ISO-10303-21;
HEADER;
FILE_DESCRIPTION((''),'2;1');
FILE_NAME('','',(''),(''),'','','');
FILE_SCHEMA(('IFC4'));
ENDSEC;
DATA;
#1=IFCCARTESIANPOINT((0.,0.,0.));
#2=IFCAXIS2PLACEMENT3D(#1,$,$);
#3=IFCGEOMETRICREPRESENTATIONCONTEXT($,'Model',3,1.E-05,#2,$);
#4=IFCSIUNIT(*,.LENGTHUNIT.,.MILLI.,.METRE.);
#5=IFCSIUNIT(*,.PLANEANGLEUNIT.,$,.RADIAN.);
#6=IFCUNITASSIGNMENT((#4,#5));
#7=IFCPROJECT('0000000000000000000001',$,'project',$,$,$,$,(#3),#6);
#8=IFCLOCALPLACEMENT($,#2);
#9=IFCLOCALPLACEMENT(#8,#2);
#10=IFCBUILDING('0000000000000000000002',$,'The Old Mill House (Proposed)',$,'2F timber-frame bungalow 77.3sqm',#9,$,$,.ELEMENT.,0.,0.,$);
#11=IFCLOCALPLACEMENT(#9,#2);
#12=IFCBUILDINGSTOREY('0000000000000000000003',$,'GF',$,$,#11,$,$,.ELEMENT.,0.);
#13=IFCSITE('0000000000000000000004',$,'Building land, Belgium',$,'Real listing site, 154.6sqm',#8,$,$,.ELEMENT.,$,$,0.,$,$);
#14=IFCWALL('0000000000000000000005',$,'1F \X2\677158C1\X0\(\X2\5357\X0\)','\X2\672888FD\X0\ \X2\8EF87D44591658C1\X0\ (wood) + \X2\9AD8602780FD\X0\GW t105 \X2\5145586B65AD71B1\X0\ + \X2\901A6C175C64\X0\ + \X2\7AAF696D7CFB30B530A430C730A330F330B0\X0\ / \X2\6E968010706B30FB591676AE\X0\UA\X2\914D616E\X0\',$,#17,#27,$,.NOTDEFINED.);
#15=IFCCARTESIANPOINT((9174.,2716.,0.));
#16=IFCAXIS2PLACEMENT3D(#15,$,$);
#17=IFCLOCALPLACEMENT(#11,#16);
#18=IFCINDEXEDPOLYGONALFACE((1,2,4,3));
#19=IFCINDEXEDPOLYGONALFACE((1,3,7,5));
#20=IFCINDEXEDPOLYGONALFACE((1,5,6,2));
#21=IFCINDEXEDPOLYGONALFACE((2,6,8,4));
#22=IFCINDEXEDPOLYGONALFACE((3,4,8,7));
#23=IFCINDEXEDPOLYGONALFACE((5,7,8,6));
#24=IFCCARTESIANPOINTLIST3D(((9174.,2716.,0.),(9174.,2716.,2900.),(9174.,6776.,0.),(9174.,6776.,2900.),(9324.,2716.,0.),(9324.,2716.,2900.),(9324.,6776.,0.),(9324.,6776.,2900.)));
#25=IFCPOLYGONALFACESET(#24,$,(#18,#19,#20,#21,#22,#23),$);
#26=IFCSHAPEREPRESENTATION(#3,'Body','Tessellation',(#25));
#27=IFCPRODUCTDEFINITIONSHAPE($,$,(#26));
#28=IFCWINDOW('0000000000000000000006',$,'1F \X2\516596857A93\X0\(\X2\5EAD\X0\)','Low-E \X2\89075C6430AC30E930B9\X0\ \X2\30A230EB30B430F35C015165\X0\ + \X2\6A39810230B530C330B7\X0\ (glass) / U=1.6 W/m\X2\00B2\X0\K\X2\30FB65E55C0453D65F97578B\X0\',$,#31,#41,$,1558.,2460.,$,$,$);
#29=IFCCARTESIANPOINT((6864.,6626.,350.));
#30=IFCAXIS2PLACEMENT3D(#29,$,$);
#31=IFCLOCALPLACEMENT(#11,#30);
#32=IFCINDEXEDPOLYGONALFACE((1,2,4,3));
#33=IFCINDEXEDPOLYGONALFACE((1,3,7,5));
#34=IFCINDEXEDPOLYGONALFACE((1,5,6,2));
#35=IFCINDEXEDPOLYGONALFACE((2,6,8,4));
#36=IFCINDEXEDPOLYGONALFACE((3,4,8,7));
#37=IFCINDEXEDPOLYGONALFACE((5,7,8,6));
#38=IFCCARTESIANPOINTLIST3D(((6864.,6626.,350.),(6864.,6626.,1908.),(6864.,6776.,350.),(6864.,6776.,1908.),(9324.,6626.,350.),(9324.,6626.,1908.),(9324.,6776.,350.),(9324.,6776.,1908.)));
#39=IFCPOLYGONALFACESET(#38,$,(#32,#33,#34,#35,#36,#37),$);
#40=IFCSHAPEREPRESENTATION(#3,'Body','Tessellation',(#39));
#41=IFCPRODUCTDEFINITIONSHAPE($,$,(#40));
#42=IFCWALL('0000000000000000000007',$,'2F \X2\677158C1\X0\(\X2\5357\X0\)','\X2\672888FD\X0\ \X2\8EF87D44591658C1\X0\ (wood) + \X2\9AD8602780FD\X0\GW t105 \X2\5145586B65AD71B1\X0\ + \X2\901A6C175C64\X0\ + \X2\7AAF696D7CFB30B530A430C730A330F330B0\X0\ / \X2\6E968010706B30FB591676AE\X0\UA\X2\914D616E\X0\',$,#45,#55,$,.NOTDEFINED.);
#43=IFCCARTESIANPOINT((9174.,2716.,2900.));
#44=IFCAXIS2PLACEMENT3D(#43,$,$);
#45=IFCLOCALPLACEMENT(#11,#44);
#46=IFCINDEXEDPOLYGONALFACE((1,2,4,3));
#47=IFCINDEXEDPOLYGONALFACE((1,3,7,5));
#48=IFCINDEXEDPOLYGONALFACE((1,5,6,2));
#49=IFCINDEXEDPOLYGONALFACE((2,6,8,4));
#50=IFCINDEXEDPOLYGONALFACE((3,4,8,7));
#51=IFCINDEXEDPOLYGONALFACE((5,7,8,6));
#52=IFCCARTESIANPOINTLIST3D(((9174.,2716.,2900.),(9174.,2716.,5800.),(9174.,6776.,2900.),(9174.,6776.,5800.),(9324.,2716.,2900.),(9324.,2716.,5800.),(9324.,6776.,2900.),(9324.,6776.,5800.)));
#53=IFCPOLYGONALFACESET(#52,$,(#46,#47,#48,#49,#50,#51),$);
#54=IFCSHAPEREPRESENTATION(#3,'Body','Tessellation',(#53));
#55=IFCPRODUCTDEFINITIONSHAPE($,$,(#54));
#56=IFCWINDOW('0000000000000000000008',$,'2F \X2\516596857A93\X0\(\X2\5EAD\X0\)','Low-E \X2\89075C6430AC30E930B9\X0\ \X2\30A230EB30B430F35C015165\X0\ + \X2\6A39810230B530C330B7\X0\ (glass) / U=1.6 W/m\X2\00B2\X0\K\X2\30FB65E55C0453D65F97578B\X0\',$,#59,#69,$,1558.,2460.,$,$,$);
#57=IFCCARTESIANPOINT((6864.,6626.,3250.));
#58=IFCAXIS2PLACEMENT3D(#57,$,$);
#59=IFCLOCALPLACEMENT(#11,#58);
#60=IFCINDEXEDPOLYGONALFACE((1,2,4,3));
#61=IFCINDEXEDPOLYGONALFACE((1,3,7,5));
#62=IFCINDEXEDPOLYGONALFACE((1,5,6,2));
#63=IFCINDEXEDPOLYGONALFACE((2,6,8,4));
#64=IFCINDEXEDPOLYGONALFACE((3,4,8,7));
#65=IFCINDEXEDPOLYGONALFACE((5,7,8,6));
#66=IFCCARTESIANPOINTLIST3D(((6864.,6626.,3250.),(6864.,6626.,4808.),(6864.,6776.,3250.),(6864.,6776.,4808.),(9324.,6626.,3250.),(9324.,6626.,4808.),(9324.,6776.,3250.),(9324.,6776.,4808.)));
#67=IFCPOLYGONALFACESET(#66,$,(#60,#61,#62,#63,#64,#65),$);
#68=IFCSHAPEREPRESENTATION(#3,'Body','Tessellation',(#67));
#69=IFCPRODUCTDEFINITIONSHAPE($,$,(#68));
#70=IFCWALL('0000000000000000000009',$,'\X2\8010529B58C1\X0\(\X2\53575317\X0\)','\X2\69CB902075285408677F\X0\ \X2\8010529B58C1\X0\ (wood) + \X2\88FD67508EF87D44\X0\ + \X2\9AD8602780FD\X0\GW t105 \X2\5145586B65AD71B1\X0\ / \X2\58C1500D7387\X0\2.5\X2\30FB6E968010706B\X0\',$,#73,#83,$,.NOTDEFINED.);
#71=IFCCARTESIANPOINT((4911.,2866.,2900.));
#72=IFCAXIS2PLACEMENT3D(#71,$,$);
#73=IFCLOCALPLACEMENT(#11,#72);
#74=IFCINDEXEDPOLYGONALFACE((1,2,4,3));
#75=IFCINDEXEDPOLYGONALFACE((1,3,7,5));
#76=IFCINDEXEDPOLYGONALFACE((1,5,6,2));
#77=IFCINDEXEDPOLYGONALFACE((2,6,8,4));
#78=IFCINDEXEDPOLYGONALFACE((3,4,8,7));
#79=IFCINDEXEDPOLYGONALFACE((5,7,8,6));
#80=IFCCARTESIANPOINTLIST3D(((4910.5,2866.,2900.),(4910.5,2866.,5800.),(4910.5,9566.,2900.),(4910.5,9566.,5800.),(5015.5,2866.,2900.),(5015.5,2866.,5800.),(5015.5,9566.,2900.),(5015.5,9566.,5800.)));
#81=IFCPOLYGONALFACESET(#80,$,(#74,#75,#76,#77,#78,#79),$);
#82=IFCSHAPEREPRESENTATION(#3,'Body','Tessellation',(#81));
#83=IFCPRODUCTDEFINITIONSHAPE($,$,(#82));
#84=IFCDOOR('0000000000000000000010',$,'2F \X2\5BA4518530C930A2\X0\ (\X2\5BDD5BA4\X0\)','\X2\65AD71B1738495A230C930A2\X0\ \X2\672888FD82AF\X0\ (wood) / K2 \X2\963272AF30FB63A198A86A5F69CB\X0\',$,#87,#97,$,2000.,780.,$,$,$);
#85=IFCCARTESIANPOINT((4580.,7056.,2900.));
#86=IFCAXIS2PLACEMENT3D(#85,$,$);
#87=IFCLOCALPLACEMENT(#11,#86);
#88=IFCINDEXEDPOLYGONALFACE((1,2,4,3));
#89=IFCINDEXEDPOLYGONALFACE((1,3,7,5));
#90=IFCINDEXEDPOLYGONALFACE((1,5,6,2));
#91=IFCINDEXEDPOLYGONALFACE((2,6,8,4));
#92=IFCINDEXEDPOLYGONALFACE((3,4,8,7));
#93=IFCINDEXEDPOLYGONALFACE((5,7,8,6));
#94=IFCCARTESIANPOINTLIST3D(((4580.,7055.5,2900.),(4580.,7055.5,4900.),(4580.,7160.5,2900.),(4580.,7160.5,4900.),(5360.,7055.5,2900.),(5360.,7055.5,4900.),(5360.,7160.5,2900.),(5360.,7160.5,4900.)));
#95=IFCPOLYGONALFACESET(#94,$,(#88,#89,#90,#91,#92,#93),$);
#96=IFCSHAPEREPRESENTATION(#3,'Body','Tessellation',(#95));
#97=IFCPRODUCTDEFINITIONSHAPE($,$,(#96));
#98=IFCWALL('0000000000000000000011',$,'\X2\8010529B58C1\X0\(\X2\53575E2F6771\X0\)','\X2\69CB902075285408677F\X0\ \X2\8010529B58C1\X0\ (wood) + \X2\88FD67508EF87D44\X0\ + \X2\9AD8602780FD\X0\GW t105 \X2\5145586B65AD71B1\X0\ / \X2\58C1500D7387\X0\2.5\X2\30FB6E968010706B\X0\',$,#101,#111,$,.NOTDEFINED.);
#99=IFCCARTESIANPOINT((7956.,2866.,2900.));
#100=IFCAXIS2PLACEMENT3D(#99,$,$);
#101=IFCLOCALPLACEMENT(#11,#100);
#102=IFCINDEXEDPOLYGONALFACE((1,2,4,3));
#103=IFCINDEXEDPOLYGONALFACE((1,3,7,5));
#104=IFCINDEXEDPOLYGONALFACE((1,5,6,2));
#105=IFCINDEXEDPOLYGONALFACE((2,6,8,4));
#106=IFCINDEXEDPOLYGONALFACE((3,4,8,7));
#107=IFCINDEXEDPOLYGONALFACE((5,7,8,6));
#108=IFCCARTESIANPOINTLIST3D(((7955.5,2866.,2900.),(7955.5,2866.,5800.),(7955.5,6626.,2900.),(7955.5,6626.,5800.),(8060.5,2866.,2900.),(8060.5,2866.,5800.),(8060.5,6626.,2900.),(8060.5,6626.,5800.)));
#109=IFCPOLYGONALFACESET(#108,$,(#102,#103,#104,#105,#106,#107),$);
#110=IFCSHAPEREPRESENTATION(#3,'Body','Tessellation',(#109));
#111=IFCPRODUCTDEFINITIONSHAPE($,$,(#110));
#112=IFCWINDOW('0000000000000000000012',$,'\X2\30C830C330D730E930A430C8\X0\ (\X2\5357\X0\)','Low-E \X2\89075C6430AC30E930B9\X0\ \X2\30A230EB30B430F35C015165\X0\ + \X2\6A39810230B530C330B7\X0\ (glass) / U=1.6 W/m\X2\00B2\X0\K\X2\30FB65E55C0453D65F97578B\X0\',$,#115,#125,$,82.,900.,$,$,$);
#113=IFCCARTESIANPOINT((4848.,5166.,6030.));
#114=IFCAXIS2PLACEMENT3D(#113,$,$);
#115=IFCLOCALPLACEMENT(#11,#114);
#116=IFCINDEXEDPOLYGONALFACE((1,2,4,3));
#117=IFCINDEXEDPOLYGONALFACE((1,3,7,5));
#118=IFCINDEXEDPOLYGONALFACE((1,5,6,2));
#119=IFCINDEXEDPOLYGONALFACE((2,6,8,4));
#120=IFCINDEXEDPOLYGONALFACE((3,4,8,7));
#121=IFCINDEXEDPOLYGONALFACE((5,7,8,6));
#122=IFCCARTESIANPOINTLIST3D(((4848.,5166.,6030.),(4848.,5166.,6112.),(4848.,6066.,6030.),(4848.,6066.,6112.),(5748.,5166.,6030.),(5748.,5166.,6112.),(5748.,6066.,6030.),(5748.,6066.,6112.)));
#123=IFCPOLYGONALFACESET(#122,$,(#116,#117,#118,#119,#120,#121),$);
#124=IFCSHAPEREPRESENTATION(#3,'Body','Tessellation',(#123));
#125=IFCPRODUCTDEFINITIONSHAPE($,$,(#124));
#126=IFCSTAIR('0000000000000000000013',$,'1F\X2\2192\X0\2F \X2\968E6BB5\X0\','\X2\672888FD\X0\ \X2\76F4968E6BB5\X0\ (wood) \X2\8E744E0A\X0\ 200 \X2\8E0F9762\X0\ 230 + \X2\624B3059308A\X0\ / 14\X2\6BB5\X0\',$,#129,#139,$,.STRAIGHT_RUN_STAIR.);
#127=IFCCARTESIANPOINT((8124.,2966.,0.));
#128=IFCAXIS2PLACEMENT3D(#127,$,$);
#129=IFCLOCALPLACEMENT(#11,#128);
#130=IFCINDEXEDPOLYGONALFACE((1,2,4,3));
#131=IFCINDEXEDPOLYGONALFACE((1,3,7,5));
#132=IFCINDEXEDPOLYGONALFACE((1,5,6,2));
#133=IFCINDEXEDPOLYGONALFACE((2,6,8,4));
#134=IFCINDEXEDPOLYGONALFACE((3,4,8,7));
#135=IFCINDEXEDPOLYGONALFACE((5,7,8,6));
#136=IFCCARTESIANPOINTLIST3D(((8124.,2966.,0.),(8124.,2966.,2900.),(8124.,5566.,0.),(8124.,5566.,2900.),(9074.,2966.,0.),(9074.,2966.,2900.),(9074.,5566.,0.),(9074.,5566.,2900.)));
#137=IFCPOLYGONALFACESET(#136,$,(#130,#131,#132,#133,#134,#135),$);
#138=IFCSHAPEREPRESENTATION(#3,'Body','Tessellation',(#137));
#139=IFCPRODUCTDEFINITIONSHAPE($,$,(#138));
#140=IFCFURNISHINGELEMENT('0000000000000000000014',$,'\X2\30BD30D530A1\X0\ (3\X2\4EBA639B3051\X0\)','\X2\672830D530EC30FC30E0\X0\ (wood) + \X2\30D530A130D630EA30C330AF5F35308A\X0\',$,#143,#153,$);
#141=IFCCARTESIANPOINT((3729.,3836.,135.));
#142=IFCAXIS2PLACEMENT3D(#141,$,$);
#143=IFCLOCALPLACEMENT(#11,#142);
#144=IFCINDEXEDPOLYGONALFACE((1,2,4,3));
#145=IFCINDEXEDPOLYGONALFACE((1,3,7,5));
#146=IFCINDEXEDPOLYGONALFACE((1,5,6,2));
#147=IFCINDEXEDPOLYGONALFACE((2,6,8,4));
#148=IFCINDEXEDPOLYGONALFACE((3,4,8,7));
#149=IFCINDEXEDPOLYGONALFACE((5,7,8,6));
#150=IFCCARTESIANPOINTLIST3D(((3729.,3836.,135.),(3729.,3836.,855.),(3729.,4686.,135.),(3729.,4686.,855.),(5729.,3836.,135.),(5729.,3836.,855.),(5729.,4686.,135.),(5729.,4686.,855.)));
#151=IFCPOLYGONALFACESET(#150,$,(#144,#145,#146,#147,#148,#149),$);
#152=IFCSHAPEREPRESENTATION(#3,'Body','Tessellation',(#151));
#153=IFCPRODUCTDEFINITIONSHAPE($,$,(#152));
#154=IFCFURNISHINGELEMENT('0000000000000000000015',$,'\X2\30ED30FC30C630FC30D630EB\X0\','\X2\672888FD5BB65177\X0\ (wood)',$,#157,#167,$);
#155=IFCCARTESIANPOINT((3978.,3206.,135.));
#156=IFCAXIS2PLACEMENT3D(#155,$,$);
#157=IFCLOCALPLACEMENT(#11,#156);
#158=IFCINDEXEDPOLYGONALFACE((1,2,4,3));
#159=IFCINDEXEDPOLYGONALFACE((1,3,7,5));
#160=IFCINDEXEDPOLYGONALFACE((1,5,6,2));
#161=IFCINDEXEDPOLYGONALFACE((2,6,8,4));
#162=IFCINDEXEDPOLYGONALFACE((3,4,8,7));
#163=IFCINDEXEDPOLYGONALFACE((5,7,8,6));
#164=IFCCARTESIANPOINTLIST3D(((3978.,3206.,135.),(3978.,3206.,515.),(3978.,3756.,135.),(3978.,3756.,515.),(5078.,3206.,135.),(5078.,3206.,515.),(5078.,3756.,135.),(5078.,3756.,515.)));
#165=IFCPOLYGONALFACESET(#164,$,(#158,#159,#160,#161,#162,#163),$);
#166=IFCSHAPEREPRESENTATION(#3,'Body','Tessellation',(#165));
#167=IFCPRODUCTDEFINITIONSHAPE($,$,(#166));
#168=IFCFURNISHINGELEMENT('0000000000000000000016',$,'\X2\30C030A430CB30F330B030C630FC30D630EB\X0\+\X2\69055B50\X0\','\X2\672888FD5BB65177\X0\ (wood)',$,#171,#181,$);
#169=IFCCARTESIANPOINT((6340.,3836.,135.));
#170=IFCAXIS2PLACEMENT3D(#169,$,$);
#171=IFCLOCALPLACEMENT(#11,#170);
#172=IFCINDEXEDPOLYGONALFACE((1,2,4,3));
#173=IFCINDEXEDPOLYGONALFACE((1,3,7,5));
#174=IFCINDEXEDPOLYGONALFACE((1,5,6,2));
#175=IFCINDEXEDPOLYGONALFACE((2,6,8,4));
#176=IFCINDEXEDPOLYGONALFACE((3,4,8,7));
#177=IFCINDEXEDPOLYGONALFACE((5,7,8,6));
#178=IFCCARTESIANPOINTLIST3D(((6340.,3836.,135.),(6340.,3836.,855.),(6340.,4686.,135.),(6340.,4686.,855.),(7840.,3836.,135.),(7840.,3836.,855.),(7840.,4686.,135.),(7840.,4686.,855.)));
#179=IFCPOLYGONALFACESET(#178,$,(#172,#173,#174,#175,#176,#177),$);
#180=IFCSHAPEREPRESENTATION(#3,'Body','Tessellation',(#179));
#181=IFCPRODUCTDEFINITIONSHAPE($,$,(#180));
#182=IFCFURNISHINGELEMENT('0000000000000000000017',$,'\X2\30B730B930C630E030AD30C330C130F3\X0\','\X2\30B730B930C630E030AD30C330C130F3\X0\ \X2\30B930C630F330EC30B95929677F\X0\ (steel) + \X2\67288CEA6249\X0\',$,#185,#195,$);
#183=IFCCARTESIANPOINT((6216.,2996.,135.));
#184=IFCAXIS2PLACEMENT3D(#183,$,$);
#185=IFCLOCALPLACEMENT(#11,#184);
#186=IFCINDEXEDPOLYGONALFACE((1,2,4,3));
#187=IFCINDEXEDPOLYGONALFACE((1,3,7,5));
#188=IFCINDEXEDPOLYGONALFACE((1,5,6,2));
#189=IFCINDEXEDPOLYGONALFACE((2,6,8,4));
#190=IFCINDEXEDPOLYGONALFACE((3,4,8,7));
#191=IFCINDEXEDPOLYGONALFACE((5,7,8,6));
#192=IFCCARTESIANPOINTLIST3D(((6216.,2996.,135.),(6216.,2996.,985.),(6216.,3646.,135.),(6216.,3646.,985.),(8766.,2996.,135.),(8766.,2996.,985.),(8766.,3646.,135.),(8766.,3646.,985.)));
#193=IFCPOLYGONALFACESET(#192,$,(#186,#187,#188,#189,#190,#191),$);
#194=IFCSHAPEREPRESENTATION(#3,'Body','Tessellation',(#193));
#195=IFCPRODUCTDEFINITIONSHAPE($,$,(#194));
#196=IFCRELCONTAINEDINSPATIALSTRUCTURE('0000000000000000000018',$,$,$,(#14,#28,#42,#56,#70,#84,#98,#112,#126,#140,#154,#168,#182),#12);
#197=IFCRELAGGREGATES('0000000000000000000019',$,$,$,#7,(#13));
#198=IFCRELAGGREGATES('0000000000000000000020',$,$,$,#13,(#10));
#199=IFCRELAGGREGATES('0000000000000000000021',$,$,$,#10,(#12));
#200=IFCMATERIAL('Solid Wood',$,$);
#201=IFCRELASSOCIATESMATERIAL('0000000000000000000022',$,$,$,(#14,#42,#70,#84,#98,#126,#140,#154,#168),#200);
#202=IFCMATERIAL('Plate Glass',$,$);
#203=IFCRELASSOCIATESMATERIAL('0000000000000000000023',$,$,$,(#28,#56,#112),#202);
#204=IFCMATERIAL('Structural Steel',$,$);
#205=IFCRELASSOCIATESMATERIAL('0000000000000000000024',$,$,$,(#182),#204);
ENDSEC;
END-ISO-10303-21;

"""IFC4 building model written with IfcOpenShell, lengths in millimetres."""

from ifc_helpers import new_model, si_unit, frame, frame_2d, origin, place, context, project, spatial, rectangle, extrude, material, element, fill, save


model = new_model("IFC4")

# Units and contexts
model_context = context("Model", 3, precision=1e-05, world=origin())
ifc_project = project(units=[si_unit("LENGTHUNIT", "METRE", prefix="MILLI"), si_unit("PLANEANGLEUNIT", "RADIAN")], contexts=[model_context])

# Site, building, storey
site_placement = place(None, origin())
site = spatial("IfcSite", under=ifc_project, at=site_placement, Name="Building land, Belgium", ObjectType="Real listing site, 154.6sqm", CompositionType="ELEMENT", RefElevation=0.0)
building_placement = place(site_placement, origin())
building = spatial("IfcBuilding", under=site, at=building_placement, Name="The Old Mill House (Proposed)", ObjectType="2F timber-frame bungalow 77.3sqm", CompositionType="ELEMENT", ElevationOfRefHeight=0.0, ElevationOfTerrain=0.0)
storey_placement = place(building_placement, origin())
storey = spatial("IfcBuildingStorey", under=building, at=storey_placement, Name="GF", CompositionType="ELEMENT", Elevation=0.0)

# Wall, opening, window
ifc_material_1 = material(Name="Solid Wood")
wall_1_placement = place(storey_placement, frame((9174.0, 2716.0, 0.0)))
wall_1 = element("IfcWall", 1, at=wall_1_placement, inside=storey, material=ifc_material_1, Name="1F 東壁(南)", Description="木製 軸組外壁 (wood) + 高性能GW t105 充填断熱 + 通気層 + 窯業系サイディング / 準耐火・外皮UA配慮", PredefinedType="NOTDEFINED", context=model_context, shape_type="SweptSolid", body=[
    extrude(rectangle(XDim=150.0, YDim=4060.0, at=frame_2d((75.0, 2030.0))), frame((9174.0, 2716.0, 0.0)), (0.0, 0.0, 1.0), 2900.0),
])
opening_1_placement = place(storey_placement, frame((6864.0, 6626.0, 350.0)))
opening_1 = element("IfcOpeningElement", 2, at=opening_1_placement, cuts=wall_1, PredefinedType="NOTDEFINED", context=model_context, shape_type="SweptSolid", body=[
    extrude(rectangle(XDim=2460.0, YDim=150.0, at=frame_2d((1230.0, 75.0))), frame((6864.0, 6626.0, 350.0)), (0.0, 0.0, 1.0), 1558.0),
])
ifc_material_2 = material(Name="Plate Glass")
window_1_placement = place(storey_placement, frame((6864.0, 6626.0, 350.0)))
window_1 = element("IfcWindow", 3, at=window_1_placement, inside=storey, material=ifc_material_2, Name="1F 入隅窓(庭)", Description="Low-E 複層ガラス アルゴン封入 + 樹脂サッシ (glass) / U=1.6 W/m²K・日射取得型", OverallHeight=1558.0, OverallWidth=2460.0, context=model_context, shape_type="SweptSolid", body=[
    extrude(rectangle(XDim=2460.0, YDim=150.0, at=frame_2d((1230.0, 75.0))), frame((6864.0, 6626.0, 350.0)), (0.0, 0.0, 1.0), 1558.0),
])
fill(opening_1, window_1)

# Wall, opening, window
wall_2_placement = place(storey_placement, frame((9174.0, 2716.0, 2900.0)))
wall_2 = element("IfcWall", 4, at=wall_2_placement, inside=storey, material=ifc_material_1, Name="2F 東壁(南)", Description="木製 軸組外壁 (wood) + 高性能GW t105 充填断熱 + 通気層 + 窯業系サイディング / 準耐火・外皮UA配慮", PredefinedType="NOTDEFINED", context=model_context, shape_type="SweptSolid", body=[
    extrude(rectangle(XDim=150.0, YDim=4060.0, at=frame_2d((75.0, 2030.0))), frame((9174.0, 2716.0, 2900.0)), (0.0, 0.0, 1.0), 2900.0),
])
opening_2_placement = place(storey_placement, frame((6864.0, 6626.0, 3250.0)))
opening_2 = element("IfcOpeningElement", 5, at=opening_2_placement, cuts=wall_2, PredefinedType="NOTDEFINED", context=model_context, shape_type="SweptSolid", body=[
    extrude(rectangle(XDim=2460.0, YDim=150.0, at=frame_2d((1230.0, 75.0))), frame((6864.0, 6626.0, 3250.0)), (0.0, 0.0, 1.0), 1558.0),
])
window_2_placement = place(storey_placement, frame((6864.0, 6626.0, 3250.0)))
window_2 = element("IfcWindow", 6, at=window_2_placement, inside=storey, material=ifc_material_2, Name="2F 入隅窓(庭)", Description="Low-E 複層ガラス アルゴン封入 + 樹脂サッシ (glass) / U=1.6 W/m²K・日射取得型", OverallHeight=1558.0, OverallWidth=2460.0, context=model_context, shape_type="SweptSolid", body=[
    extrude(rectangle(XDim=2460.0, YDim=150.0, at=frame_2d((1230.0, 75.0))), frame((6864.0, 6626.0, 3250.0)), (0.0, 0.0, 1.0), 1558.0),
])
fill(opening_2, window_2)

# Wall, opening, door
wall_3_placement = place(storey_placement, frame((4911.0, 2866.0, 2900.0)))
wall_3 = element("IfcWall", 7, at=wall_3_placement, inside=storey, material=ifc_material_1, Name="耐力壁(南北)", Description="構造用合板 耐力壁 (wood) + 製材軸組 + 高性能GW t105 充填断熱 / 壁倍率2.5・準耐火", PredefinedType="NOTDEFINED", context=model_context, shape_type="SweptSolid", body=[
    extrude(rectangle(XDim=105.0, YDim=6700.0, at=frame_2d((52.0, 3350.0))), frame((4911.0, 2866.0, 2900.0)), (0.0, 0.0, 1.0), 2900.0),
])
opening_3_placement = place(storey_placement, frame((4580.0, 7056.0, 2900.0)))
opening_3 = element("IfcOpeningElement", 8, at=opening_3_placement, cuts=wall_3, PredefinedType="NOTDEFINED", context=model_context, shape_type="SweptSolid", body=[
    extrude(rectangle(XDim=780.0, YDim=105.0, at=frame_2d((390.0, 52.0))), frame((4580.0, 7056.0, 2900.0)), (0.0, 0.0, 1.0), 2000.0),
])
door_1_placement = place(storey_placement, frame((4580.0, 7056.0, 2900.0)))
door_1 = element("IfcDoor", 9, at=door_1_placement, inside=storey, material=ifc_material_1, Name="2F 室内ドア (寝室)", Description="断熱玄関ドア 木製芯 (wood) / K2 防犯・採風機構", OverallHeight=2000.0, OverallWidth=780.0, context=model_context, shape_type="SweptSolid", body=[
    extrude(rectangle(XDim=780.0, YDim=105.0, at=frame_2d((390.0, 52.0))), frame((4580.0, 7056.0, 2900.0)), (0.0, 0.0, 1.0), 2000.0),
])
fill(opening_3, door_1)

# Wall
wall_4_placement = place(storey_placement, frame((7956.0, 2866.0, 2900.0)))
element("IfcWall", 10, at=wall_4_placement, inside=storey, material=ifc_material_1, Name="耐力壁(南帯東)", Description="構造用合板 耐力壁 (wood) + 製材軸組 + 高性能GW t105 充填断熱 / 壁倍率2.5・準耐火", PredefinedType="NOTDEFINED", context=model_context, shape_type="SweptSolid", body=[
    extrude(rectangle(XDim=105.0, YDim=3760.0, at=frame_2d((52.0, 1880.0))), frame((7956.0, 2866.0, 2900.0)), (0.0, 0.0, 1.0), 2900.0),
])

# Window
window_3_placement = place(storey_placement, frame((4848.0, 5166.0, 6030.0)))
element("IfcWindow", 11, at=window_3_placement, inside=storey, material=ifc_material_2, Name="トップライト (南)", Description="Low-E 複層ガラス アルゴン封入 + 樹脂サッシ (glass) / U=1.6 W/m²K・日射取得型", OverallHeight=82.0, OverallWidth=900.0, context=model_context, shape_type="SweptSolid", body=[
    extrude(rectangle(XDim=900.0, YDim=900.0, at=frame_2d((450.0, 450.0))), frame((4848.0, 5166.0, 6030.0)), (0.0, 0.0, 1.0), 82.0),
])

# Stair
stair_placement = place(storey_placement, frame((8124.0, 2966.0, 0.0)))
element("IfcStair", 12, at=stair_placement, inside=storey, material=ifc_material_1, Name="1F→2F 階段", Description="木製 直階段 (wood) 蹴上 200 踏面 230 + 手すり / 14段", PredefinedType="STRAIGHT_RUN_STAIR", context=model_context, shape_type="SweptSolid", body=[
    extrude(rectangle(XDim=950.0, YDim=2600.0, at=frame_2d((475.0, 1300.0))), frame((8124.0, 2966.0, 0.0)), (0.0, 0.0, 1.0), 2900.0),
])

# Furnishing elements
furnishing_1_placement = place(storey_placement, frame((3729.0, 3836.0, 135.0)))
element("IfcFurnishingElement", 13, at=furnishing_1_placement, inside=storey, material=ifc_material_1, Name="ソファ (3人掛け)", Description="木フレーム (wood) + ファブリック張り", context=model_context, shape_type="SweptSolid", body=[
    extrude(rectangle(XDim=2000.0, YDim=850.0, at=frame_2d((1000.0, 425.0))), frame((3729.0, 3836.0, 135.0)), (0.0, 0.0, 1.0), 720.0),
])
furnishing_2_placement = place(storey_placement, frame((3978.0, 3206.0, 135.0)))
element("IfcFurnishingElement", 14, at=furnishing_2_placement, inside=storey, material=ifc_material_1, Name="ローテーブル", Description="木製家具 (wood)", context=model_context, shape_type="SweptSolid", body=[
    extrude(rectangle(XDim=1100.0, YDim=550.0, at=frame_2d((550.0, 275.0))), frame((3978.0, 3206.0, 135.0)), (0.0, 0.0, 1.0), 380.0),
])
furnishing_3_placement = place(storey_placement, frame((6340.0, 3836.0, 135.0)))
element("IfcFurnishingElement", 15, at=furnishing_3_placement, inside=storey, material=ifc_material_1, Name="ダイニングテーブル+椅子", Description="木製家具 (wood)", context=model_context, shape_type="SweptSolid", body=[
    extrude(rectangle(XDim=1500.0, YDim=850.0, at=frame_2d((750.0, 425.0))), frame((6340.0, 3836.0, 135.0)), (0.0, 0.0, 1.0), 720.0),
])
ifc_material_3 = material(Name="Structural Steel")
furnishing_4_placement = place(storey_placement, frame((6216.0, 2996.0, 135.0)))
element("IfcFurnishingElement", 16, at=furnishing_4_placement, inside=storey, material=ifc_material_3, Name="システムキッチン", Description="システムキッチン ステンレス天板 (steel) + 木質扉", context=model_context, shape_type="SweptSolid", body=[
    extrude(rectangle(XDim=2550.0, YDim=650.0, at=frame_2d((1275.0, 325.0))), frame((6216.0, 2996.0, 135.0)), (0.0, 0.0, 1.0), 850.0),
])

save(model, "model.ifc")
